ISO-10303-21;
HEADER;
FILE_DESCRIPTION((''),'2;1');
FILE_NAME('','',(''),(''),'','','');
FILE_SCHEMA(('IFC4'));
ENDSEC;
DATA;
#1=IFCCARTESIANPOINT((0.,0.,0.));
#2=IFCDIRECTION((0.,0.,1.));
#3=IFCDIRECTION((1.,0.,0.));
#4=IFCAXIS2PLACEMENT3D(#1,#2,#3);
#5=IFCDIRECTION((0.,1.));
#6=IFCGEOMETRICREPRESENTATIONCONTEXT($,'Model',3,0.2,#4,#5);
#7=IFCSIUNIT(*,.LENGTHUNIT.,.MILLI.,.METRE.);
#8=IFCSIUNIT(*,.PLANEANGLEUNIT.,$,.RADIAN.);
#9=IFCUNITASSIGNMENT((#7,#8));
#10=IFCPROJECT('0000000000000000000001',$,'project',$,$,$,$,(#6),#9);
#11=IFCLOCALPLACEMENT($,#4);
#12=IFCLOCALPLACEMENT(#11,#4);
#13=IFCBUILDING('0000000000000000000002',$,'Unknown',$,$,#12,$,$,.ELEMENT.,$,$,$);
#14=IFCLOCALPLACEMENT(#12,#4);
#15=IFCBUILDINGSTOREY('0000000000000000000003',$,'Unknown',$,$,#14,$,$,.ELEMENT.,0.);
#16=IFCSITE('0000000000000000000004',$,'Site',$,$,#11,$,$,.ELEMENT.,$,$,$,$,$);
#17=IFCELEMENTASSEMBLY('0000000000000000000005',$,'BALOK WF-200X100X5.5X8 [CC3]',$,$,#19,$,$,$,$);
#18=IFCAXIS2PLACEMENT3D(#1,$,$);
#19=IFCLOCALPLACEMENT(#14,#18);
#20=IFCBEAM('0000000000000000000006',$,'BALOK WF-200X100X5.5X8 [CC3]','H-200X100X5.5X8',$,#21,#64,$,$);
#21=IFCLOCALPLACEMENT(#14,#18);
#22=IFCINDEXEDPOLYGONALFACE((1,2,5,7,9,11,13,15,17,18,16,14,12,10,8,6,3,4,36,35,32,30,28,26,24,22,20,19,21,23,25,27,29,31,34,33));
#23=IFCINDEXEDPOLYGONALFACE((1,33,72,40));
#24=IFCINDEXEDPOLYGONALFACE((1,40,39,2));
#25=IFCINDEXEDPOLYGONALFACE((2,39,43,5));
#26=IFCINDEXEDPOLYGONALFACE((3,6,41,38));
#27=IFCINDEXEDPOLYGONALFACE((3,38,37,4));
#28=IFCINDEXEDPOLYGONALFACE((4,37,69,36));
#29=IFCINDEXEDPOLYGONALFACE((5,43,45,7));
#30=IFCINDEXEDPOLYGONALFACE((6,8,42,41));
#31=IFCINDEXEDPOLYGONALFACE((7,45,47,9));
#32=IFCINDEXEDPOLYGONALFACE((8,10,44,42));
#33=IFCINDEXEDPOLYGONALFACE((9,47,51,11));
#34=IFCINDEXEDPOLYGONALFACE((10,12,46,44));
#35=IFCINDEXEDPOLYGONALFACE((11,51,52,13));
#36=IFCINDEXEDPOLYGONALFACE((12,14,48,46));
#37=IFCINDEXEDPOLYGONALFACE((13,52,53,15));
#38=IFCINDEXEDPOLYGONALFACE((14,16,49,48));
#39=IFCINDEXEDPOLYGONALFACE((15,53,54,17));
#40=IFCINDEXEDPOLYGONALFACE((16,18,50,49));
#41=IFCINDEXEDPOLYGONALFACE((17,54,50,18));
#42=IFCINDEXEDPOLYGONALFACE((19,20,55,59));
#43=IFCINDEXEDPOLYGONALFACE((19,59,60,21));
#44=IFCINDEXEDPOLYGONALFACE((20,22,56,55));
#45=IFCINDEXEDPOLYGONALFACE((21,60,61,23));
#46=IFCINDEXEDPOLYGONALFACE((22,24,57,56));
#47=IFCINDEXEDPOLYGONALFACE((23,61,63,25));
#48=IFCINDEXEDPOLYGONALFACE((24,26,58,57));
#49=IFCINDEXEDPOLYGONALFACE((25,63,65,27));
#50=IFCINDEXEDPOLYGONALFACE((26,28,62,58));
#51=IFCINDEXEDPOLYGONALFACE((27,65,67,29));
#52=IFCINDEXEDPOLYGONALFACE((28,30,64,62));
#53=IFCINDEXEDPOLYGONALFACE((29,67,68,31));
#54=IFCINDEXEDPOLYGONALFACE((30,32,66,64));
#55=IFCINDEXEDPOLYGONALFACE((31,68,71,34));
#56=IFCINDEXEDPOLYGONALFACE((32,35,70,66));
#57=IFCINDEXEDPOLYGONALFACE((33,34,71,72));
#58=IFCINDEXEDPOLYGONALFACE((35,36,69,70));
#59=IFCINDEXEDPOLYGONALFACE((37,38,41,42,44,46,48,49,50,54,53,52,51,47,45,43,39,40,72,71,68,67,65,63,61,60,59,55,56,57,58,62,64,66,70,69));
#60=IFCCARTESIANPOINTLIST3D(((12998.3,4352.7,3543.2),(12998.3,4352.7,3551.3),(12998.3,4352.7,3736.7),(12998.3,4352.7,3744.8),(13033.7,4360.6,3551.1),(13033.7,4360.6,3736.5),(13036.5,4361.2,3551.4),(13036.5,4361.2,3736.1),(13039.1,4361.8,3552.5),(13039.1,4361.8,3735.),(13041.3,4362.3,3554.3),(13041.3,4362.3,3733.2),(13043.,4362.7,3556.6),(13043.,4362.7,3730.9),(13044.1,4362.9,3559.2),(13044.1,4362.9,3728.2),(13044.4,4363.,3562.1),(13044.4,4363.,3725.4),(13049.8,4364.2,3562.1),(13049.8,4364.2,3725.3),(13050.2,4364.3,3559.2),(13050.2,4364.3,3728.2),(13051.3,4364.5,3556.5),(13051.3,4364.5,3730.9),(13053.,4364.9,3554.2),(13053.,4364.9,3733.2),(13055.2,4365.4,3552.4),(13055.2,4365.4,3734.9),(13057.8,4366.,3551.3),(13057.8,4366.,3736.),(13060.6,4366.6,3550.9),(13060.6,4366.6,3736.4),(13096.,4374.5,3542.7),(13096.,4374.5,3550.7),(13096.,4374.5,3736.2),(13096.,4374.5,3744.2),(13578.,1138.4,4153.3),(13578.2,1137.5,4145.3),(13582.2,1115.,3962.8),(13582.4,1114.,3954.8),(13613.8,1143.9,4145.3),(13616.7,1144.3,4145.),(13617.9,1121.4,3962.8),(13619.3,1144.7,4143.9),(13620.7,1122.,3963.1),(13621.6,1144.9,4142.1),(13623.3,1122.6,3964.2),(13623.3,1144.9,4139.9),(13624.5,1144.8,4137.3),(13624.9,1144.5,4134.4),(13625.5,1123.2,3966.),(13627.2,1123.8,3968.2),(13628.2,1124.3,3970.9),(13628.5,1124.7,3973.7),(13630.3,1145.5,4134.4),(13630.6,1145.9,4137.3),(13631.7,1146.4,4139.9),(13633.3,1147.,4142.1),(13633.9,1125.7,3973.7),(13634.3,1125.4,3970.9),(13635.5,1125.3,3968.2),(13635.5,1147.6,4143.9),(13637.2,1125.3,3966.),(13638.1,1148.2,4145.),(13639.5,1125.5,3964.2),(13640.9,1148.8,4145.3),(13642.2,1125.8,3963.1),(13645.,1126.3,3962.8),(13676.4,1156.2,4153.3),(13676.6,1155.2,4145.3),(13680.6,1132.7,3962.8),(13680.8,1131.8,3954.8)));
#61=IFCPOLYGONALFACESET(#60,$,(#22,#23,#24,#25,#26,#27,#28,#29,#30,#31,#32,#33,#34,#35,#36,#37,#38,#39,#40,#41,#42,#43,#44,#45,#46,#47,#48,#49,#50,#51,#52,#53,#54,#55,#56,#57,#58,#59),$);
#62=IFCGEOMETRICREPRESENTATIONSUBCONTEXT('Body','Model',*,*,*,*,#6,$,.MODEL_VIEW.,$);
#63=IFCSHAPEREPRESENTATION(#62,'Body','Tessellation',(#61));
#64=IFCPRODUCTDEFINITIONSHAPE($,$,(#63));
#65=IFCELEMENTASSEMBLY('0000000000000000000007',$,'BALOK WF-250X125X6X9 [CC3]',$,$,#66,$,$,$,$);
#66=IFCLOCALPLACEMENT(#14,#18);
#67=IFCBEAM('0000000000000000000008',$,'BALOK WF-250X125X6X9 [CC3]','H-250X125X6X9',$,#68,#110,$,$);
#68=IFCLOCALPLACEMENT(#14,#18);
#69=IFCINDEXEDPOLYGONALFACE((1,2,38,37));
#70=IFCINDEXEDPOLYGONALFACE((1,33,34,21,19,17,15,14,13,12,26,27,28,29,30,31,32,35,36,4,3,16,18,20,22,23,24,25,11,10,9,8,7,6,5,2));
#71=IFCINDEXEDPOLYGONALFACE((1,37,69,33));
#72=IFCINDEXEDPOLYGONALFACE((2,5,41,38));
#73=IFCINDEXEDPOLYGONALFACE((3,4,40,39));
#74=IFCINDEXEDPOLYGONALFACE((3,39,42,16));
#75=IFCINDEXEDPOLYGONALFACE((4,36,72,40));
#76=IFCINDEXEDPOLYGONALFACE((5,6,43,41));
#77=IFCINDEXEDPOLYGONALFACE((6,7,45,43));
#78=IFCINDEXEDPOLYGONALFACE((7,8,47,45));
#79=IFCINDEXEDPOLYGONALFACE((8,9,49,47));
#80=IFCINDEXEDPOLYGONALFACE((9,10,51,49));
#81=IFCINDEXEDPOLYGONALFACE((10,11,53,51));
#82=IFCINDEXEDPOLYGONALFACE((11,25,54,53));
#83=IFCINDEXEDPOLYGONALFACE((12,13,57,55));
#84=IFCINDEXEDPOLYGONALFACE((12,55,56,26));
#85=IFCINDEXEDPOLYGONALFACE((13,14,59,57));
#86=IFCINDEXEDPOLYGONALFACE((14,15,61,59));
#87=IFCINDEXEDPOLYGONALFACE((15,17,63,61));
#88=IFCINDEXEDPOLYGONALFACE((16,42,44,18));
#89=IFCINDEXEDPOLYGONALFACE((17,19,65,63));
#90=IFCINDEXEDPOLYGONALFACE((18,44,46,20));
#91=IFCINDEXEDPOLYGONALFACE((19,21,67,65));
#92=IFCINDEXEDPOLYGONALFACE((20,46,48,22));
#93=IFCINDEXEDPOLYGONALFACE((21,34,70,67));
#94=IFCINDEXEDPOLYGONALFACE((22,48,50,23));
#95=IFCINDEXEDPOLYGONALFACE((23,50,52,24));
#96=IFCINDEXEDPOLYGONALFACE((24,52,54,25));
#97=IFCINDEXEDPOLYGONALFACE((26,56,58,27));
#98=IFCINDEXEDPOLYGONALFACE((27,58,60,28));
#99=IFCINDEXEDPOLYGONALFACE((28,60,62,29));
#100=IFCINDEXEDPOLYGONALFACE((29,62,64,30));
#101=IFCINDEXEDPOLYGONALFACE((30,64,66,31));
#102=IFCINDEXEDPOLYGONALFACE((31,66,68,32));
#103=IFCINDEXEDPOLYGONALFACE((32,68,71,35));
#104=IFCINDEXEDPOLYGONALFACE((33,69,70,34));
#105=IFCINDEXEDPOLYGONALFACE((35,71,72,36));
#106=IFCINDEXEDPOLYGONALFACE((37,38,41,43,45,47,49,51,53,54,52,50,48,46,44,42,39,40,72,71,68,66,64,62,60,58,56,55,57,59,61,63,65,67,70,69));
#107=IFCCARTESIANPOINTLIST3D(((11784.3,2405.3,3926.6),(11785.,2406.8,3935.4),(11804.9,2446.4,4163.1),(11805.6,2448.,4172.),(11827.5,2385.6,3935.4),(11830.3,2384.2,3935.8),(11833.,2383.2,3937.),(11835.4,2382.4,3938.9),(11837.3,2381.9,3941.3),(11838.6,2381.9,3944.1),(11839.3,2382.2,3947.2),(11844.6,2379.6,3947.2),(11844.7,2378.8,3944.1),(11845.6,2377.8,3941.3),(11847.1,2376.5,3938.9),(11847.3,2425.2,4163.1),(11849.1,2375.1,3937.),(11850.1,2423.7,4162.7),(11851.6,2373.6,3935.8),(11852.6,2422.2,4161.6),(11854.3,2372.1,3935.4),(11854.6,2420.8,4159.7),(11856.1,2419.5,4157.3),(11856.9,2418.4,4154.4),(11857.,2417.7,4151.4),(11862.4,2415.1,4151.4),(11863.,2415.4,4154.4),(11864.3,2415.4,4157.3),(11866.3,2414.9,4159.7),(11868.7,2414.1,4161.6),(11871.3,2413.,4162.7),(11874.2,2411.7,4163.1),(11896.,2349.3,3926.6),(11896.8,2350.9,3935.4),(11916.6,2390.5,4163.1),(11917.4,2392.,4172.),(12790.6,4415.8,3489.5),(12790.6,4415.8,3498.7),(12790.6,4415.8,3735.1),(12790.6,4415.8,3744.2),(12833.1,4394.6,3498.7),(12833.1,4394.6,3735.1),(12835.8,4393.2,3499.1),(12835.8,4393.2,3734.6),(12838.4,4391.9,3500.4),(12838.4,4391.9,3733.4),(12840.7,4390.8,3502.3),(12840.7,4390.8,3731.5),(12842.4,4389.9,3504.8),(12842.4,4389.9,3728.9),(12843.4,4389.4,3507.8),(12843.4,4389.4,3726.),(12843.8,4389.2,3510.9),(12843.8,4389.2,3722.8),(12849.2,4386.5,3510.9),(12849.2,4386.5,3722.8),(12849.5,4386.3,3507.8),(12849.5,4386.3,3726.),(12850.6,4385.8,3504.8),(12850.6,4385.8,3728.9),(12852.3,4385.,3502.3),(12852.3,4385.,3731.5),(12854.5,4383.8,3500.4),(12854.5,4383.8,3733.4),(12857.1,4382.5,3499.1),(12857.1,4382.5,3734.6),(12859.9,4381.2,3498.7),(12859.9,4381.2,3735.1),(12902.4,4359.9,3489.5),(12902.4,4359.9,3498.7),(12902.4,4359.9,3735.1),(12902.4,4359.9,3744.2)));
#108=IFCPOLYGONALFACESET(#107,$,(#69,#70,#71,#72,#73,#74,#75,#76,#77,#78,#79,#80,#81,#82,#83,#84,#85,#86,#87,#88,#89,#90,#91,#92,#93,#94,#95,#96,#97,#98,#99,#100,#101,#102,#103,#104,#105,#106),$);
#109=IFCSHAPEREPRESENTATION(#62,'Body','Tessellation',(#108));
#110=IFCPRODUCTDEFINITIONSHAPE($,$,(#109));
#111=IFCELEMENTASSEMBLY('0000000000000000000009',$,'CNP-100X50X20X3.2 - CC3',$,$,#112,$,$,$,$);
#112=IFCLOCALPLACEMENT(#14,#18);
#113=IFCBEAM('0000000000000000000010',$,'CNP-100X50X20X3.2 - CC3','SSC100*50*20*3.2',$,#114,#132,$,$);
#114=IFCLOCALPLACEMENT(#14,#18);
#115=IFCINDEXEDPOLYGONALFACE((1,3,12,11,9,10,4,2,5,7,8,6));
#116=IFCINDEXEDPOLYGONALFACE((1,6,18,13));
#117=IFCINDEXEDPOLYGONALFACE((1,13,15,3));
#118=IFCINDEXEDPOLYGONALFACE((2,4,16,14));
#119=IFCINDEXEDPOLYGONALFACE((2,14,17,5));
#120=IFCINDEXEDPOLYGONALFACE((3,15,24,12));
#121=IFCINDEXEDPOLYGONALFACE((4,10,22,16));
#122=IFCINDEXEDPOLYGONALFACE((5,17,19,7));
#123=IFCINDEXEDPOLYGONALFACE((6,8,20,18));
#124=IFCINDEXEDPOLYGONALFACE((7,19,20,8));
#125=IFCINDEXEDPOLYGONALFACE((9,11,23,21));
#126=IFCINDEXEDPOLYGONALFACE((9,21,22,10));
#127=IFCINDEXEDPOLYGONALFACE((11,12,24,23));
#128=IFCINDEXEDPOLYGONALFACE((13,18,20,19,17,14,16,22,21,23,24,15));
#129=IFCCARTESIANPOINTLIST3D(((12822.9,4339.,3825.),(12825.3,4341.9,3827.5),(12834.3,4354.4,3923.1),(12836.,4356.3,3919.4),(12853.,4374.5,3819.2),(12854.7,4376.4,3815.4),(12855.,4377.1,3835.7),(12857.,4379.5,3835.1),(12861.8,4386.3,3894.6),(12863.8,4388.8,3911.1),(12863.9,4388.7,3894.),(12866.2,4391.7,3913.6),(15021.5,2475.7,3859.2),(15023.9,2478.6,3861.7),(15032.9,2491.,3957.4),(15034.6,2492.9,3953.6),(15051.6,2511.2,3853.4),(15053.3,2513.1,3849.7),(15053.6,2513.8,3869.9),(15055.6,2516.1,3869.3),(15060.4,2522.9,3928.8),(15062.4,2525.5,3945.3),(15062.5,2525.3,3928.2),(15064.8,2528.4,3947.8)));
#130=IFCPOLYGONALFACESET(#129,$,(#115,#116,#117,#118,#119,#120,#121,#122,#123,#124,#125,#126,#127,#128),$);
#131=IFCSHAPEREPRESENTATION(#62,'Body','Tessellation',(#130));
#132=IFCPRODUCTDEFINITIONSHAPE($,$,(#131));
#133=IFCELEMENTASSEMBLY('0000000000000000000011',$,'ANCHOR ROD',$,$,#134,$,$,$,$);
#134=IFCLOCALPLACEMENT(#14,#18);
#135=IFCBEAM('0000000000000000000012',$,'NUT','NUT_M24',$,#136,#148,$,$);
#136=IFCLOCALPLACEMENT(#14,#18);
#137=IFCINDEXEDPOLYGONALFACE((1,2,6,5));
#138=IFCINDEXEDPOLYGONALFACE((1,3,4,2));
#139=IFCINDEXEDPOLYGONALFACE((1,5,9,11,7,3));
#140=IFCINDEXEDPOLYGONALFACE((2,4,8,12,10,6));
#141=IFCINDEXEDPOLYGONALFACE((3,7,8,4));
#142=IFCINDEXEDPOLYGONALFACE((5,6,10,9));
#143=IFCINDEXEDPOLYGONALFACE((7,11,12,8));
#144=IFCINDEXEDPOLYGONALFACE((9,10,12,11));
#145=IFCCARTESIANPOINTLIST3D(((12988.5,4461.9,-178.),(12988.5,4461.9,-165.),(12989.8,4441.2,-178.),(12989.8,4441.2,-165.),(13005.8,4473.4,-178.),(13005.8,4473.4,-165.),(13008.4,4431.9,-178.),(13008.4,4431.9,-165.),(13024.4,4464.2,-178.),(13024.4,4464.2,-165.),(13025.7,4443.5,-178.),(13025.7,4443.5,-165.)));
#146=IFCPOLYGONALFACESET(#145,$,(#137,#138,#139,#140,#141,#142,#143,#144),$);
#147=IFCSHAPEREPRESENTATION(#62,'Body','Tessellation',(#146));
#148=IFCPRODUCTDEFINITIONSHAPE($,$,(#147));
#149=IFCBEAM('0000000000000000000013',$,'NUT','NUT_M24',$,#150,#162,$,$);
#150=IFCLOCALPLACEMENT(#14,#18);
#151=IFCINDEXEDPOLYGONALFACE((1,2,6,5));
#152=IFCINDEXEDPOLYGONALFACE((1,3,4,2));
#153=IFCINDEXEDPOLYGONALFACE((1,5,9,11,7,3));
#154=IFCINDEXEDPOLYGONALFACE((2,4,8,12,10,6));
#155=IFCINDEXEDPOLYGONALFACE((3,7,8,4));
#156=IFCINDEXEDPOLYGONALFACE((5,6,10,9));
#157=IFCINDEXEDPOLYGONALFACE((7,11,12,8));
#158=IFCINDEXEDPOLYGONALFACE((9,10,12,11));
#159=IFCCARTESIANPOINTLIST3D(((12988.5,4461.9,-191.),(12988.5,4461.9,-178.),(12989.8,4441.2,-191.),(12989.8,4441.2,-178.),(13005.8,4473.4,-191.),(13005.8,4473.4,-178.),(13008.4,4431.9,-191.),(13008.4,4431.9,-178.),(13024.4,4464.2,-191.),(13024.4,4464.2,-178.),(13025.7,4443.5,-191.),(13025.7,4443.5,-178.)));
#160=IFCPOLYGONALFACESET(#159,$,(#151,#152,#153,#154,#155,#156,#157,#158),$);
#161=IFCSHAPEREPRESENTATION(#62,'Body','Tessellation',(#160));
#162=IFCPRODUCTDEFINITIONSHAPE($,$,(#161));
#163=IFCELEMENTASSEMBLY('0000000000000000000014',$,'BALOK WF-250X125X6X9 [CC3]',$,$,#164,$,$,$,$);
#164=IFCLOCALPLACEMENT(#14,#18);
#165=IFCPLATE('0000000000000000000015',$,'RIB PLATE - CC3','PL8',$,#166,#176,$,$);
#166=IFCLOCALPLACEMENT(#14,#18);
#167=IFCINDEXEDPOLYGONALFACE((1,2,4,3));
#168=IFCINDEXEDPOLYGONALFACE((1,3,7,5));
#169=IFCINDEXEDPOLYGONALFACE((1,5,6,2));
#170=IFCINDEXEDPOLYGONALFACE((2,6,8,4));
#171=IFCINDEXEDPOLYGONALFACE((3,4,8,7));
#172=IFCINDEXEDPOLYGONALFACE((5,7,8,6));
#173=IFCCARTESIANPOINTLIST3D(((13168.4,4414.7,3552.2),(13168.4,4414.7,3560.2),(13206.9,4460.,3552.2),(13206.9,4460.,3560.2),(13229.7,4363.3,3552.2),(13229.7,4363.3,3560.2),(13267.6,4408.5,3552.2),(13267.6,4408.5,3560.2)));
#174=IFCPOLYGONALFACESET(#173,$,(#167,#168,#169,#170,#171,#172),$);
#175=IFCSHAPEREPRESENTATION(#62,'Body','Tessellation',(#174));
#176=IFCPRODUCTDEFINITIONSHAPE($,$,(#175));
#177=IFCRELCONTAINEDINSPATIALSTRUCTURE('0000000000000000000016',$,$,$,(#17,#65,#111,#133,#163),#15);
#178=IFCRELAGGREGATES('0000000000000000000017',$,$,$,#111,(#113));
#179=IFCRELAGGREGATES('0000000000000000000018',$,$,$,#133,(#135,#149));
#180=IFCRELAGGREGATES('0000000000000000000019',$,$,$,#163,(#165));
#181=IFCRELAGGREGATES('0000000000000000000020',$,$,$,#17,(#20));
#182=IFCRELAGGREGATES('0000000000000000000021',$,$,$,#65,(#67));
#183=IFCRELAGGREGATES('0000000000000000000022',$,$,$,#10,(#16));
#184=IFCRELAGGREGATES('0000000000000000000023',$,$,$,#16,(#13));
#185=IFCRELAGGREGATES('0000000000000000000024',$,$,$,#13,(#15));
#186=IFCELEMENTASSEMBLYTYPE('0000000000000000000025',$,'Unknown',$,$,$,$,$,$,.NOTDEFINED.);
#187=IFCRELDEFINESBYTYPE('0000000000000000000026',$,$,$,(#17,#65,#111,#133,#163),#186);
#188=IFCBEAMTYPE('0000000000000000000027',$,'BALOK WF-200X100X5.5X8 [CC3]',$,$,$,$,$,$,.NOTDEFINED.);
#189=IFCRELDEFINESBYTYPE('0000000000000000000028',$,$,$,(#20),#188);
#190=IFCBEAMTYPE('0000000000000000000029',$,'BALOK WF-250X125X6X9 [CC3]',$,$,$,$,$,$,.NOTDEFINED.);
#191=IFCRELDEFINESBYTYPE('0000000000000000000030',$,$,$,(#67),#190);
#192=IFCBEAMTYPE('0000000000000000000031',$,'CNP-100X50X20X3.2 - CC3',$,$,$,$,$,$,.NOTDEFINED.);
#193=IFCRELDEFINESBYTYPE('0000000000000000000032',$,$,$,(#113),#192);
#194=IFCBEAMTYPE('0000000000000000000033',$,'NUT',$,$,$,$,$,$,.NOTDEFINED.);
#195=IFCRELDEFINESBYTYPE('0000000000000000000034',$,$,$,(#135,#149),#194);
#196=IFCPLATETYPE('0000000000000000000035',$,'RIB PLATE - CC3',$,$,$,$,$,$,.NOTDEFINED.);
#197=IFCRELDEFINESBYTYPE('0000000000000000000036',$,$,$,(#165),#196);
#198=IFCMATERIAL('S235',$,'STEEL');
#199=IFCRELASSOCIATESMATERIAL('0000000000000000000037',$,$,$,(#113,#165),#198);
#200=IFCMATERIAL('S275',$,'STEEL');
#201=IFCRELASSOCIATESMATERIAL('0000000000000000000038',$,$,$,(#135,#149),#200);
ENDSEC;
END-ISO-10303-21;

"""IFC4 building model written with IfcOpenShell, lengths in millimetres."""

from ifc_helpers import new_model, si_unit, direction, frame, origin_with_axes, origin_2d_with_axis, place, context, subcontext, project, spatial, polyline, line, indexed_curve, i_section, c_section, outline, extrude, clip, halfspace, material, material_profile, profile_set, profile_usage, type_object, element, aggregate, save


model = new_model("IFC4")

# Units and contexts
model_context = context("Model", 3, precision=0.2, world=origin_with_axes(), true_north=direction((0.0, 1.0)))
body_context = subcontext(model_context, "Body", "Model", "MODEL_VIEW")
ifc_project = project(units=[si_unit("LENGTHUNIT", "METRE", prefix="MILLI"), si_unit("PLANEANGLEUNIT", "RADIAN")], contexts=[model_context])

# Site, building, storey
site_placement = place(None, origin_with_axes())
site = spatial("IfcSite", under=ifc_project, at=site_placement, Name="Site", CompositionType="ELEMENT")
building_placement = place(site_placement, origin_with_axes())
building = spatial("IfcBuilding", under=site, at=building_placement, Name="Unknown", CompositionType="ELEMENT")
storey_placement = place(building_placement, origin_with_axes())
storey = spatial("IfcBuildingStorey", under=building, at=storey_placement, Name="Unknown", CompositionType="ELEMENT", Elevation=0.0)

# Element assemblies, beams
element_assembly_type = type_object("IfcElementAssemblyType", Name="Unknown", PredefinedType="NOTDEFINED")
assembly_1_placement = place(storey_placement, frame((13043.5, 4384.0, 3641.1), z_axis=(0.984123, 0.17749, 0.0), x_axis=(0.176118, -0.976513, 0.124114)))
assembly_1 = element("IfcElementAssembly", 1, at=assembly_1_placement, inside=storey, type_object=element_assembly_type, Name="BALOK WF-200X100X5.5X8 [CC3]")
beam_type_1 = type_object("IfcBeamType", Name="BALOK WF-200X100X5.5X8 [CC3]", PredefinedType="NOTDEFINED")
beam_1_placement = place(assembly_1_placement, origin_with_axes())
beam_1 = element("IfcBeam", 2, at=beam_1_placement, type_object=beam_type_1, Name="BALOK WF-200X100X5.5X8 [CC3]", Description="H-200X100X5.5X8", context=body_context, shape_type="Clipping", body=[
    clip(clip(extrude(i_section(OverallWidth=100.0, OverallDepth=200.0, WebThickness=5.5, FlangeThickness=8.0, FilletRadius=11.0, FlangeEdgeRadius=0.0, FlangeSlope=0.0, at=origin_2d_with_axis()), frame((0.0, 0.0, 0.0), z_axis=(-1.0, 0.0, 0.0), x_axis=(0.0, 0.0, 1.0)), (0.0, 0.0, -1.0), 3327.0), halfspace(frame((33.4, -99.6, -51.7), z_axis=(-0.991435, -0.124009, -0.040956), x_axis=(-0.040226, -0.008391, 0.999155)), False)), halfspace(frame((35.4, -100.0, -50.0), z_axis=(-0.991438, -0.12401, -0.040887), x_axis=(-0.041205, 0.0, 0.999151)), False)),
])
assembly_2_placement = place(storey_placement, frame((12861.4, 4417.6, 3610.4), z_axis=(-0.89424, 0.447588, 0.0), x_axis=(-0.439365, -0.87781, 0.190809)))
assembly_2 = element("IfcElementAssembly", 3, at=assembly_2_placement, inside=storey, type_object=element_assembly_type, Name="BALOK WF-250X125X6X9 [CC3]")
beam_type_2 = type_object("IfcBeamType", Name="BALOK WF-250X125X6X9 [CC3]", PredefinedType="NOTDEFINED")
beam_2_placement = place(assembly_2_placement, origin_with_axes())
beam_2 = element("IfcBeam", 4, at=beam_2_placement, type_object=beam_type_2, Name="BALOK WF-250X125X6X9 [CC3]", Description="H-250X125X6X9", context=body_context, shape_type="Clipping", body=[
    clip(clip(extrude(i_section(OverallWidth=125.0, OverallDepth=250.0, WebThickness=6.0, FlangeThickness=9.0, FilletRadius=12.0, FlangeEdgeRadius=0.0, FlangeSlope=0.0, at=origin_2d_with_axis()), frame((0.0, 0.0, 0.0), z_axis=(-1.0, 0.0, 0.0), x_axis=(0.0, 0.0, 1.0)), (0.0, 0.0, -1.0), 2300.0), halfspace(frame((7.4, -125.6, -62.5), z_axis=(-0.981608, 0.190908, 0.0), x_axis=(0.0, 0.0, 1.0)), False)), halfspace(frame((9.6, -125.0, -62.5), z_axis=(-0.981627, 0.190809, 0.000011), x_axis=(0.000011, 0.0, 1.0)), False)),
])
assembly_3_placement = place(storey_placement, frame((12844.5, 4365.4, 3869.3), z_axis=(0.636394, 0.747395, -0.190796), x_axis=(0.762822, -0.646499, 0.011875)))
assembly_3 = element("IfcElementAssembly", 5, at=assembly_3_placement, inside=storey, type_object=element_assembly_type, Name="CNP-100X50X20X3.2 - CC3")
ifc_material_1 = material(Name="S235", Category="STEEL")
ifc_material_profile_1 = material_profile(ifc_material_1, c_section(Depth=100.0, Width=50.0, WallThickness=3.2, Girth=20.0, at=origin_2d_with_axis()), Name="SSC100*50*20*3.2")
ifc_profile_set_1 = profile_set([ifc_material_profile_1])
ifc_profile_usage_1 = profile_usage(ifc_profile_set_1, cardinal=4)
beam_type_3 = type_object("IfcBeamType", Name="CNP-100X50X20X3.2 - CC3", PredefinedType="NOTDEFINED")
beam_3_placement = place(assembly_3_placement, origin_with_axes())
beam_3 = element("IfcBeam", 6, at=beam_3_placement, type_object=beam_type_3, material=ifc_profile_usage_1, Name="CNP-100X50X20X3.2 - CC3", Description="SSC100*50*20*3.2", context=body_context, shape_type="SolidModel", body=[
    extrude(c_section(Depth=100.0, Width=50.0, WallThickness=3.2, Girth=20.0, at=origin_2d_with_axis()), frame((0.0, 0.0, 0.0), z_axis=(-1.0, 0.0, 0.0), x_axis=(0.0, 0.0, 1.0)), (0.0, 0.0, -1.0), 2882.2),
])
aggregate(assembly_3, [beam_3])

# Element assembly, beams
assembly_4_placement = place(storey_placement, frame((13007.1, 4452.7, -151.0), z_axis=(0.447009, 0.89453, 0.0), x_axis=(0.0, 0.0, -1.0)))
assembly_4 = element("IfcElementAssembly", 7, at=assembly_4_placement, inside=storey, type_object=element_assembly_type, Name="ANCHOR ROD")
ifc_material_2 = material(Name="S275", Category="STEEL")
ifc_material_profile_2 = material_profile(ifc_material_2, outline(polyline([(18.0, 10.4), (0.0, 20.8), (-18.0, 10.4), (-18.0, -10.4), (0.0, -20.8), (18.0, -10.4), (18.0, 10.4)])), Name="NUT_M24")
ifc_profile_set_2 = profile_set([ifc_material_profile_2])
ifc_profile_usage_2 = profile_usage(ifc_profile_set_2, cardinal=5)
beam_type_4 = type_object("IfcBeamType", Name="NUT", PredefinedType="NOTDEFINED")
beam_4_placement = place(assembly_4_placement, frame((14.0, 0.0, 0.0), z_axis=(0.0, 0.003456, 0.999994), x_axis=(1.0, 0.0, 0.0)))
beam_4 = element("IfcBeam", 8, at=beam_4_placement, type_object=beam_type_4, material=ifc_profile_usage_2, Name="NUT", Description="NUT_M24", context=body_context, shape_type="SolidModel", body=[
    extrude(outline(polyline([(18.0, 10.4), (0.0, 20.8), (-18.0, 10.4), (-18.0, -10.4), (0.0, -20.8), (18.0, -10.4), (18.0, 10.4)])), frame((0.0, 0.0, 0.0), z_axis=(-1.0, 0.0, 0.0), x_axis=(0.0, 0.0, 1.0)), (0.0, 0.0, -1.0), 13.0),
])
beam_5_placement = place(assembly_4_placement, frame((27.0, 0.0, 0.0), z_axis=(0.0, 0.003456, 0.999994), x_axis=(1.0, 0.0, 0.0)))
beam_5 = element("IfcBeam", 9, at=beam_5_placement, type_object=beam_type_4, material=ifc_profile_usage_2, Name="NUT", Description="NUT_M24", context=body_context, shape_type="SolidModel", body=[
    extrude(outline(polyline([(18.0, 10.4), (0.0, 20.8), (-18.0, 10.4), (-18.0, -10.4), (0.0, -20.8), (18.0, -10.4), (18.0, 10.4)])), frame((0.0, 0.0, 0.0), z_axis=(-1.0, 0.0, 0.0), x_axis=(0.0, 0.0, 1.0)), (0.0, 0.0, -1.0), 13.0),
])
aggregate(assembly_4, [beam_4, beam_5])

# Element assembly, plate
assembly_5_placement = place(storey_placement, frame((13206.5, 4464.3, 3619.2), z_axis=(-0.646722, -0.762726, 0.0), x_axis=(0.762726, -0.646722, 0.0)))
assembly_5 = element("IfcElementAssembly", 10, at=assembly_5_placement, inside=storey, type_object=element_assembly_type, Name="BALOK WF-250X125X6X9 [CC3]")
ifc_material_profile_3 = material_profile(ifc_material_1, outline(indexed_curve([(0.0, 0.0), (80.0, 0.0), (80.0, 59.0), (0.4, 59.5)], segments=[line(1, 2, 3, 4, 1)])), Name="PL8")
ifc_profile_set_3 = profile_set([ifc_material_profile_3])
ifc_profile_usage_3 = profile_usage(ifc_profile_set_3, cardinal=5)
plate_type_1 = type_object("IfcPlateType", Name="RIB PLATE - CC3", PredefinedType="NOTDEFINED")
plate_1_placement = place(assembly_5_placement, frame((3.1, -63.0, 62.5), z_axis=(0.0, 1.0, 0.0), x_axis=(0.999982, 0.0, -0.006019)))
plate_1 = element("IfcPlate", 11, at=plate_1_placement, type_object=plate_type_1, material=ifc_profile_usage_3, Name="RIB PLATE - CC3", Description="PL8", context=body_context, shape_type="SolidModel", body=[
    extrude(outline(indexed_curve([(0.0, 0.0), (80.0, 0.0), (80.0, 59.0), (0.4, 59.5)], segments=[line(1, 2, 3, 4, 1)])), frame((0.0, 0.0, 4.0), z_axis=(0.0, 0.0, 1.0), x_axis=(1.0, 0.0, 0.0)), (0.0, 0.0, -1.0), 8.0),
])
aggregate(assembly_5, [plate_1])

aggregate(assembly_1, [beam_1])

aggregate(assembly_2, [beam_2])

save(model, "model.ifc")
